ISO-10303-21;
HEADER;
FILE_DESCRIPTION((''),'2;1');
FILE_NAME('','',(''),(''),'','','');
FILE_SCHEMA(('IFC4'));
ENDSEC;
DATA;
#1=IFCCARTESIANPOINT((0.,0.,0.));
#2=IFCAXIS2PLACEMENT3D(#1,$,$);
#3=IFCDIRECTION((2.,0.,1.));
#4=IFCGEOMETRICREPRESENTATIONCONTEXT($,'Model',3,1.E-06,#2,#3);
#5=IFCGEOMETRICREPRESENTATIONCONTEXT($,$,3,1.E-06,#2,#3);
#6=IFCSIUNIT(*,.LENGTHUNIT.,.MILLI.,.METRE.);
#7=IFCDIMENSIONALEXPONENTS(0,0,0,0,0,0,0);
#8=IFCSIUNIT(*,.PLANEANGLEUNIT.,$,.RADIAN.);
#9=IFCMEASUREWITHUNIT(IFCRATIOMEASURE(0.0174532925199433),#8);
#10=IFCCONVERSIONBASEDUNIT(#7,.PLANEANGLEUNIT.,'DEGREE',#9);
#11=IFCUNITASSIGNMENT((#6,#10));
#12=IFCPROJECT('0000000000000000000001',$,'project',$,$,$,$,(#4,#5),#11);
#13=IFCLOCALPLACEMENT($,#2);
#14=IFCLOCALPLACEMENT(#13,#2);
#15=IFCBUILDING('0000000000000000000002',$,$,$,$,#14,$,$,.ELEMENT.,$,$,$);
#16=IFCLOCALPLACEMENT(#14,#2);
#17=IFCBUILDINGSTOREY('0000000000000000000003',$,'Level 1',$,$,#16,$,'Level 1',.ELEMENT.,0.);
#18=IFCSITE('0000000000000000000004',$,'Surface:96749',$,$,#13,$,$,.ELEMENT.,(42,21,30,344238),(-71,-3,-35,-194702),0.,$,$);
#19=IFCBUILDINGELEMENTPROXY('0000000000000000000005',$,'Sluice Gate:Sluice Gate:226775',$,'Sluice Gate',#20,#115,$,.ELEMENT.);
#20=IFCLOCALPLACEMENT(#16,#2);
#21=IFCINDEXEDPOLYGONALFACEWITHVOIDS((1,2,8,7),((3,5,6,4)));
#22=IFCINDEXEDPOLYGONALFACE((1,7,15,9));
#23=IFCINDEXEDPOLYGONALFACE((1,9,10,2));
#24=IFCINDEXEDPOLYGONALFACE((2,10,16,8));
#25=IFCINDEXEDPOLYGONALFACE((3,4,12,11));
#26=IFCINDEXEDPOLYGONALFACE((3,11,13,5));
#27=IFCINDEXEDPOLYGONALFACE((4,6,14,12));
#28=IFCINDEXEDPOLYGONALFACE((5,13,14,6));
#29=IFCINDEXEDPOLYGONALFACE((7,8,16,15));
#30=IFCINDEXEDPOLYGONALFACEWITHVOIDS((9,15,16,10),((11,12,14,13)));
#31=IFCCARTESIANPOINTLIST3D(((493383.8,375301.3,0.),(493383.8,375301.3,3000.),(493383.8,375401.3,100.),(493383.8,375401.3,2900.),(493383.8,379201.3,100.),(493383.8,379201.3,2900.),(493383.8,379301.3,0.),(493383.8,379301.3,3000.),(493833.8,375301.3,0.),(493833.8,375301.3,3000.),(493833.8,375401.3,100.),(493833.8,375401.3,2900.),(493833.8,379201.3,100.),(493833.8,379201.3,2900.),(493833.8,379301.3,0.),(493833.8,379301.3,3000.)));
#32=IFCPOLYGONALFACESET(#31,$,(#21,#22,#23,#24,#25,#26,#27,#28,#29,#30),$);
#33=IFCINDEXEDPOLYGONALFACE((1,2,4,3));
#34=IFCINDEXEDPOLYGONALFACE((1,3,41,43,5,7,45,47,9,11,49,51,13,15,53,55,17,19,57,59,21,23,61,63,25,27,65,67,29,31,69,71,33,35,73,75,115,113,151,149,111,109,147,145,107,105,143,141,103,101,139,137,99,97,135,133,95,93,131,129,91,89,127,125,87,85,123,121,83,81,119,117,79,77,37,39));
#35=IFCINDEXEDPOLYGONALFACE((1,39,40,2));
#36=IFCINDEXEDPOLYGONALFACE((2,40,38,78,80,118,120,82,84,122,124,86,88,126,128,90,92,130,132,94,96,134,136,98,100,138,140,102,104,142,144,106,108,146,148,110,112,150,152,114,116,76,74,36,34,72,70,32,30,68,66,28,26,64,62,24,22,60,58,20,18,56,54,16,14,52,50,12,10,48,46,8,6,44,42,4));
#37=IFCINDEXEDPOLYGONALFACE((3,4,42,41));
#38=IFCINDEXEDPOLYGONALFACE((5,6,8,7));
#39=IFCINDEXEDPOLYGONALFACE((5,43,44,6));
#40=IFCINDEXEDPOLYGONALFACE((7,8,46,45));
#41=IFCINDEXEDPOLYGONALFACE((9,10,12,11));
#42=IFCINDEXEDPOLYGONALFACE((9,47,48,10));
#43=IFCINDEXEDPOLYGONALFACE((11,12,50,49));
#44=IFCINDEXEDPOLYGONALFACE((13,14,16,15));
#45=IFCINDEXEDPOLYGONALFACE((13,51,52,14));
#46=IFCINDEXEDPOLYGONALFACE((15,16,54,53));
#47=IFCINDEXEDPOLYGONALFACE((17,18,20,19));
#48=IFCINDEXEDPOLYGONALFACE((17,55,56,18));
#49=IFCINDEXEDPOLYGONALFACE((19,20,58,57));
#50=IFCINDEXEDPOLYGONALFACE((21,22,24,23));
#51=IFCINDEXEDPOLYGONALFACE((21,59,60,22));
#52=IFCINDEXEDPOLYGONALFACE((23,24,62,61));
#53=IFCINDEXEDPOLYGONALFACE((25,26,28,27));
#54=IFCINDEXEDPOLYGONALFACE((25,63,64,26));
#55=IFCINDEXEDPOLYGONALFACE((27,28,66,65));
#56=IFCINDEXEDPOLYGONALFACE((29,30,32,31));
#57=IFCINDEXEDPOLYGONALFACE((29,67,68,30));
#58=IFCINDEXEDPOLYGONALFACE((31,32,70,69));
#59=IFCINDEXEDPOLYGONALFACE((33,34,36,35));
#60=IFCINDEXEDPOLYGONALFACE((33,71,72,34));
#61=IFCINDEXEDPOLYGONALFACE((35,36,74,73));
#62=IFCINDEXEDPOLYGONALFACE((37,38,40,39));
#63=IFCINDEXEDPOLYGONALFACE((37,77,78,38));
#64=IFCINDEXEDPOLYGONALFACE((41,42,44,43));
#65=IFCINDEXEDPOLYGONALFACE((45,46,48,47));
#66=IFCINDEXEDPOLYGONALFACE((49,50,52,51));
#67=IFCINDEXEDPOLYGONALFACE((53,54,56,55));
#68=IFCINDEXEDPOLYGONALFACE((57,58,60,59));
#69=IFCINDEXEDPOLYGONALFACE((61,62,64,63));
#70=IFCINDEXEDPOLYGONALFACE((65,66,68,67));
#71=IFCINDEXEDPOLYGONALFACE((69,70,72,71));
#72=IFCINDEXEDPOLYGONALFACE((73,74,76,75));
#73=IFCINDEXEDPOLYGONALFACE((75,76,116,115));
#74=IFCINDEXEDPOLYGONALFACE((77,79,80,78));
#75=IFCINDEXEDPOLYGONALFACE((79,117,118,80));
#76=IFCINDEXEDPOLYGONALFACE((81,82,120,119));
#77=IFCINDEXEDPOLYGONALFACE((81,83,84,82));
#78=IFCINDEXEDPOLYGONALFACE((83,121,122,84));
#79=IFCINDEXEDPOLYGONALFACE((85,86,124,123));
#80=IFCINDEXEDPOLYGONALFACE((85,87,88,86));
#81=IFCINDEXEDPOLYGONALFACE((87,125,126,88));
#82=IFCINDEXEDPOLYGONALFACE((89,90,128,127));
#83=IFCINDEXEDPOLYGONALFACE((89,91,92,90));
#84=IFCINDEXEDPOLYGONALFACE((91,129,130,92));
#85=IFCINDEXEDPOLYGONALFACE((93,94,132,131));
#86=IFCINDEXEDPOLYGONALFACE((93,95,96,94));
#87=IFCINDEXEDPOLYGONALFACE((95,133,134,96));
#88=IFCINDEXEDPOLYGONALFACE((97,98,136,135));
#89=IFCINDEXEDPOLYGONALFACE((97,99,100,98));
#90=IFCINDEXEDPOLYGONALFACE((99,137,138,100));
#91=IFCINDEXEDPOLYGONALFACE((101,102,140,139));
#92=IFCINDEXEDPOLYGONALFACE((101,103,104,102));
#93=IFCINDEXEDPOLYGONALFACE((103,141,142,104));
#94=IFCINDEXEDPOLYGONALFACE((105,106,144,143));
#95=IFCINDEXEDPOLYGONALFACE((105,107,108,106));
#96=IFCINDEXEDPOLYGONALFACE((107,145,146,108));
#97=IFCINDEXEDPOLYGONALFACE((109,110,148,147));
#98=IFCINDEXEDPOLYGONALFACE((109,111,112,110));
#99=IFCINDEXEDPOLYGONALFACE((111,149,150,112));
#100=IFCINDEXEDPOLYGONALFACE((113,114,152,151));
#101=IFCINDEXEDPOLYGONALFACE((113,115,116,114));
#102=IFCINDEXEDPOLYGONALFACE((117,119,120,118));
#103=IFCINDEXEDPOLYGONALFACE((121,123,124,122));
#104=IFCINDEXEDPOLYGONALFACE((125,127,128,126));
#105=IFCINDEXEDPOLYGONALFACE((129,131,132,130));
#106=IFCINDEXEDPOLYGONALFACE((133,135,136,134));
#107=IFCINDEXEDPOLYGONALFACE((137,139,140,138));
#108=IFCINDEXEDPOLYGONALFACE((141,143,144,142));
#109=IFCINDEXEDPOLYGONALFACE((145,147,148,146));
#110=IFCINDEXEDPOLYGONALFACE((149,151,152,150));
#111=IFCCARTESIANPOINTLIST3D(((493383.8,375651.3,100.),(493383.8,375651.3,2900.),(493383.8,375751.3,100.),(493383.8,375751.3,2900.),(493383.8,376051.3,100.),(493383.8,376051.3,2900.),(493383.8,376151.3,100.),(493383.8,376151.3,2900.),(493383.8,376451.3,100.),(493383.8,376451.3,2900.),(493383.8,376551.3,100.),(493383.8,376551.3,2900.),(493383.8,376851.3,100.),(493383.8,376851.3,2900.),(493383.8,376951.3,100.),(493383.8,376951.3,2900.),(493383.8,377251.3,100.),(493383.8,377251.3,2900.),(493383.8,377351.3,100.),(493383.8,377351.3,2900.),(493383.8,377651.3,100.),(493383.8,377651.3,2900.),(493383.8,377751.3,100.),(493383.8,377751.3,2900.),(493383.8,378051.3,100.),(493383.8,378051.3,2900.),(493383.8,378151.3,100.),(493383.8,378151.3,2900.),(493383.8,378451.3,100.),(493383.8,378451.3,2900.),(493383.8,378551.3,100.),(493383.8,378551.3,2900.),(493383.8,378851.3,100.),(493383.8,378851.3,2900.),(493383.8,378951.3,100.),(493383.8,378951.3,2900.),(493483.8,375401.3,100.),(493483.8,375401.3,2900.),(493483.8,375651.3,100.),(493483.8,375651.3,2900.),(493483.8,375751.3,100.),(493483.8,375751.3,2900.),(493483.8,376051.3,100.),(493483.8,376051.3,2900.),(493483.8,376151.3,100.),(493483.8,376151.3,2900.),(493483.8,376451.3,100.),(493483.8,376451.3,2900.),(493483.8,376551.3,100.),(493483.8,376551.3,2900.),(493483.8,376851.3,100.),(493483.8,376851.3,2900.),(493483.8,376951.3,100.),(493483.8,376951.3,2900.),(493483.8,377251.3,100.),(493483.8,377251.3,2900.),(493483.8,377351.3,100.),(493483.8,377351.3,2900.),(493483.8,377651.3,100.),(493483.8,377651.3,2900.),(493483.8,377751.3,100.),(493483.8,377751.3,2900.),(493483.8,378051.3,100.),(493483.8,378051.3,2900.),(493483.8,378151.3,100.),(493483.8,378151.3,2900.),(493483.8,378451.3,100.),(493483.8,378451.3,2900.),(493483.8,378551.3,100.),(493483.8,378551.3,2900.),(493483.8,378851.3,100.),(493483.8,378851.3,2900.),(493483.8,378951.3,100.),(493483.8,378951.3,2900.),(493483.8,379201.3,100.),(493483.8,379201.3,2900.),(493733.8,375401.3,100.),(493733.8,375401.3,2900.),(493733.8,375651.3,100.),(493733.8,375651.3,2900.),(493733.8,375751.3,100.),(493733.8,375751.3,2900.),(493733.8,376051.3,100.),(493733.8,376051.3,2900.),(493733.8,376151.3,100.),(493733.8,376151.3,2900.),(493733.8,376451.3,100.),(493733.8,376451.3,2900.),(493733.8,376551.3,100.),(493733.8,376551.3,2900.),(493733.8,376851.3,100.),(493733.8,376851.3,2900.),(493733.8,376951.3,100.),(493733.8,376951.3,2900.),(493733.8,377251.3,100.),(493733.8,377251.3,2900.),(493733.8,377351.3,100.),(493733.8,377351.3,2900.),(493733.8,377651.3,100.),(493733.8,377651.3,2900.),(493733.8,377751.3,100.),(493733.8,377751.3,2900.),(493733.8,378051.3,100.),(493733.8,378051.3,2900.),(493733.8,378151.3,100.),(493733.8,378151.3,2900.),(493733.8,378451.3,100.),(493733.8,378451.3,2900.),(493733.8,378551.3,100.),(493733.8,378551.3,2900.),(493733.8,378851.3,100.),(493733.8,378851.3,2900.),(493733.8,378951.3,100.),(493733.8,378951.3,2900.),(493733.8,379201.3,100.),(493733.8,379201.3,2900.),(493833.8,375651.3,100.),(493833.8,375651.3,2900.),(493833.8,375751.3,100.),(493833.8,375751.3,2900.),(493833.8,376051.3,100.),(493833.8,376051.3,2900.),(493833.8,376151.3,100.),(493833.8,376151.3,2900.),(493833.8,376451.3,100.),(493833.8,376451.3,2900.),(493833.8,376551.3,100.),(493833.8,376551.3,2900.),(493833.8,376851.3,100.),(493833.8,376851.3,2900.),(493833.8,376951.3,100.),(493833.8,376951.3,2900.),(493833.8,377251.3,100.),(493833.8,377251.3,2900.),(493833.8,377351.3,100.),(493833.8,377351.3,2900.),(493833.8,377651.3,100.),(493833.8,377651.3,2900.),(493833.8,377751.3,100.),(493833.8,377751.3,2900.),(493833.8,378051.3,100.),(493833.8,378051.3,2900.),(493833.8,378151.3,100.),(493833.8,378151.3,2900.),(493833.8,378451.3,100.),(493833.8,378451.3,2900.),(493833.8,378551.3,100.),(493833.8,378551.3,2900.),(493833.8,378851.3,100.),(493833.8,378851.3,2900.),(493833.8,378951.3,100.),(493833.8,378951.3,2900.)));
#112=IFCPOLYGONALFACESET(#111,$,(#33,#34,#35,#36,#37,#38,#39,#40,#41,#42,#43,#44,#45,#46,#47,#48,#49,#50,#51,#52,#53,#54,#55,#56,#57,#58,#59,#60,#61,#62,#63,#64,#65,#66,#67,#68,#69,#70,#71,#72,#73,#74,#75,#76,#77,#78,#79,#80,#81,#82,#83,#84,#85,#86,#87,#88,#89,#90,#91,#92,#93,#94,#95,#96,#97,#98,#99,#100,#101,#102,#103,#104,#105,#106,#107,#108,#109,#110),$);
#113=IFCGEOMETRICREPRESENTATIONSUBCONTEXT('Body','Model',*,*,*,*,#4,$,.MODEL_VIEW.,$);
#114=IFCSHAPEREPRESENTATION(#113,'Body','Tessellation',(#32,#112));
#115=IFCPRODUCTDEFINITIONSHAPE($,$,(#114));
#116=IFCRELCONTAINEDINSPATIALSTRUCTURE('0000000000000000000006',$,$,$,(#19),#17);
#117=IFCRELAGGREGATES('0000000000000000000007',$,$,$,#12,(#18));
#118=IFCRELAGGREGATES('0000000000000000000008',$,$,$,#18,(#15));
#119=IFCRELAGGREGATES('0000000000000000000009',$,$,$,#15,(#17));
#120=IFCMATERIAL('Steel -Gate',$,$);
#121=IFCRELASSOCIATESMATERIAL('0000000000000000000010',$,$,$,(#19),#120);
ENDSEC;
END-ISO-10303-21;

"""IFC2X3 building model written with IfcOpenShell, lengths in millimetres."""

from ifc_helpers import new_model, entity, si_unit, converted_unit, direction, frame, origin, place, context, subcontext, project, spatial, polyline, outline, extrude, source, transform, mapped, material, element, save


model = new_model("IFC2X3")

# Units and contexts
model_context = context("Model", 3, precision=1e-06, world=origin(), true_north=direction((2.0, 0.0, 1.0)))
context_of_model = context(None, 3, precision=1e-06, world=origin(), true_north=direction((2.0, 0.0, 1.0)))
body_context = subcontext(model_context, "Body", "Model", "MODEL_VIEW")
ifc_project = project(units=[si_unit("LENGTHUNIT", "METRE", prefix="MILLI"), converted_unit("PLANEANGLEUNIT", "DEGREE", entity("IfcRatioMeasure", 0.0174532925199433), si_unit("PLANEANGLEUNIT", "RADIAN"), dimensions=[0, 0, 0, 0, 0, 0, 0])], contexts=[model_context, context_of_model])

# Site, building, storey
site_placement = place(None, origin())
site = spatial("IfcSite", under=ifc_project, at=site_placement, Name="Surface:96749", CompositionType="ELEMENT", RefLatitude=(42, 21, 30, 344238), RefLongitude=(-71, -3, -35, -194702), RefElevation=0.0)
building_placement = place(site_placement, origin())
building = spatial("IfcBuilding", under=site, at=building_placement, CompositionType="ELEMENT")
storey_placement = place(building_placement, origin())
storey = spatial("IfcBuildingStorey", under=building, at=storey_placement, Name="Level 1", LongName="Level 1", CompositionType="ELEMENT", Elevation=0.0)

# Building element proxy
ifc_material = material(Name="Steel -Gate")
shared_shape_1 = source(origin(), body_context, "Body", "SweptSolid", [
    extrude(outline(polyline([(-2000.0, -1500.0), (2000.0, -1500.0), (2000.0, 1500.0), (-2000.0, 1500.0), (-2000.0, -1500.0)]), holes=[polyline([(-1900.0, 1400.0), (1900.0, 1400.0), (1900.0, -1400.0), (-1900.0, -1400.0), (-1900.0, 1400.0)])]), frame((0.0, -225.0, 1500.0), z_axis=(0.0, 1.0, 0.0), x_axis=(-1.0, 0.0, 0.0)), (0.0, 0.0, 1.0), 450.0),
    extrude(outline(polyline([(125.0, -1650.0), (225.0, -1650.0), (225.0, -1550.0), (125.0, -1550.0), (125.0, -1250.0), (225.0, -1250.0), (225.0, -1150.0), (125.0, -1150.0), (125.0, -850.0), (225.0, -850.0), (225.0, -750.0), (125.0, -750.0), (125.0, -450.0), (225.0, -450.0), (225.0, -350.0), (125.0, -350.0), (125.0, -50.0), (225.0, -50.0), (225.0, 50.0), (125.0, 50.0), (125.0, 350.0), (225.0, 350.0), (225.0, 450.0), (125.0, 450.0), (125.0, 750.0), (225.0, 750.0), (225.0, 850.0), (125.0, 850.0), (125.0, 1150.0), (225.0, 1150.0), (225.0, 1250.0), (125.0, 1250.0), (125.0, 1550.0), (225.0, 1550.0), (225.0, 1650.0), (125.0, 1650.0), (125.0, 1900.0), (-125.0, 1900.0), (-125.0, 1650.0), (-225.0, 1650.0), (-225.0, 1550.0), (-125.0, 1550.0), (-125.0, 1250.0), (-225.0, 1250.0), (-225.0, 1150.0), (-125.0, 1150.0), (-125.0, 850.0), (-225.0, 850.0), (-225.0, 750.0), (-125.0, 750.0), (-125.0, 450.0), (-225.0, 450.0), (-225.0, 350.0), (-125.0, 350.0), (-125.0, 50.0), (-225.0, 50.0), (-225.0, -50.0), (-125.0, -50.0), (-125.0, -350.0), (-225.0, -350.0), (-225.0, -450.0), (-125.0, -450.0), (-125.0, -750.0), (-225.0, -750.0), (-225.0, -850.0), (-125.0, -850.0), (-125.0, -1150.0), (-225.0, -1150.0), (-225.0, -1250.0), (-125.0, -1250.0), (-125.0, -1550.0), (-225.0, -1550.0), (-225.0, -1650.0), (-125.0, -1650.0), (-125.0, -1900.0), (125.0, -1900.0), (125.0, -1650.0)])), frame((0.0, 0.0, 100.0), z_axis=(0.0, 0.0, 1.0), x_axis=(0.0, -1.0, 0.0)), (0.0, 0.0, 1.0), 2800.0),
])
for number, where, z_axis, x_axis, name in (
    (1, (493608.8, 377301.3, 0.0), (0.0, 0.0, 1.0), (0.0, 1.0, 0.0), "Sluice Gate:Sluice Gate:226775"),
):
    element("IfcBuildingElementProxy", number, at=place(storey_placement, frame(where, z_axis=z_axis, x_axis=x_axis)), inside=storey, material=ifc_material, Name=name, ObjectType="Sluice Gate", CompositionType="ELEMENT", context=body_context, shape_type="MappedRepresentation", body=[
        mapped(shared_shape_1, transform((0.0, 0.0, 0.0), scale=1.0)),
    ])

save(model, "model.ifc")
